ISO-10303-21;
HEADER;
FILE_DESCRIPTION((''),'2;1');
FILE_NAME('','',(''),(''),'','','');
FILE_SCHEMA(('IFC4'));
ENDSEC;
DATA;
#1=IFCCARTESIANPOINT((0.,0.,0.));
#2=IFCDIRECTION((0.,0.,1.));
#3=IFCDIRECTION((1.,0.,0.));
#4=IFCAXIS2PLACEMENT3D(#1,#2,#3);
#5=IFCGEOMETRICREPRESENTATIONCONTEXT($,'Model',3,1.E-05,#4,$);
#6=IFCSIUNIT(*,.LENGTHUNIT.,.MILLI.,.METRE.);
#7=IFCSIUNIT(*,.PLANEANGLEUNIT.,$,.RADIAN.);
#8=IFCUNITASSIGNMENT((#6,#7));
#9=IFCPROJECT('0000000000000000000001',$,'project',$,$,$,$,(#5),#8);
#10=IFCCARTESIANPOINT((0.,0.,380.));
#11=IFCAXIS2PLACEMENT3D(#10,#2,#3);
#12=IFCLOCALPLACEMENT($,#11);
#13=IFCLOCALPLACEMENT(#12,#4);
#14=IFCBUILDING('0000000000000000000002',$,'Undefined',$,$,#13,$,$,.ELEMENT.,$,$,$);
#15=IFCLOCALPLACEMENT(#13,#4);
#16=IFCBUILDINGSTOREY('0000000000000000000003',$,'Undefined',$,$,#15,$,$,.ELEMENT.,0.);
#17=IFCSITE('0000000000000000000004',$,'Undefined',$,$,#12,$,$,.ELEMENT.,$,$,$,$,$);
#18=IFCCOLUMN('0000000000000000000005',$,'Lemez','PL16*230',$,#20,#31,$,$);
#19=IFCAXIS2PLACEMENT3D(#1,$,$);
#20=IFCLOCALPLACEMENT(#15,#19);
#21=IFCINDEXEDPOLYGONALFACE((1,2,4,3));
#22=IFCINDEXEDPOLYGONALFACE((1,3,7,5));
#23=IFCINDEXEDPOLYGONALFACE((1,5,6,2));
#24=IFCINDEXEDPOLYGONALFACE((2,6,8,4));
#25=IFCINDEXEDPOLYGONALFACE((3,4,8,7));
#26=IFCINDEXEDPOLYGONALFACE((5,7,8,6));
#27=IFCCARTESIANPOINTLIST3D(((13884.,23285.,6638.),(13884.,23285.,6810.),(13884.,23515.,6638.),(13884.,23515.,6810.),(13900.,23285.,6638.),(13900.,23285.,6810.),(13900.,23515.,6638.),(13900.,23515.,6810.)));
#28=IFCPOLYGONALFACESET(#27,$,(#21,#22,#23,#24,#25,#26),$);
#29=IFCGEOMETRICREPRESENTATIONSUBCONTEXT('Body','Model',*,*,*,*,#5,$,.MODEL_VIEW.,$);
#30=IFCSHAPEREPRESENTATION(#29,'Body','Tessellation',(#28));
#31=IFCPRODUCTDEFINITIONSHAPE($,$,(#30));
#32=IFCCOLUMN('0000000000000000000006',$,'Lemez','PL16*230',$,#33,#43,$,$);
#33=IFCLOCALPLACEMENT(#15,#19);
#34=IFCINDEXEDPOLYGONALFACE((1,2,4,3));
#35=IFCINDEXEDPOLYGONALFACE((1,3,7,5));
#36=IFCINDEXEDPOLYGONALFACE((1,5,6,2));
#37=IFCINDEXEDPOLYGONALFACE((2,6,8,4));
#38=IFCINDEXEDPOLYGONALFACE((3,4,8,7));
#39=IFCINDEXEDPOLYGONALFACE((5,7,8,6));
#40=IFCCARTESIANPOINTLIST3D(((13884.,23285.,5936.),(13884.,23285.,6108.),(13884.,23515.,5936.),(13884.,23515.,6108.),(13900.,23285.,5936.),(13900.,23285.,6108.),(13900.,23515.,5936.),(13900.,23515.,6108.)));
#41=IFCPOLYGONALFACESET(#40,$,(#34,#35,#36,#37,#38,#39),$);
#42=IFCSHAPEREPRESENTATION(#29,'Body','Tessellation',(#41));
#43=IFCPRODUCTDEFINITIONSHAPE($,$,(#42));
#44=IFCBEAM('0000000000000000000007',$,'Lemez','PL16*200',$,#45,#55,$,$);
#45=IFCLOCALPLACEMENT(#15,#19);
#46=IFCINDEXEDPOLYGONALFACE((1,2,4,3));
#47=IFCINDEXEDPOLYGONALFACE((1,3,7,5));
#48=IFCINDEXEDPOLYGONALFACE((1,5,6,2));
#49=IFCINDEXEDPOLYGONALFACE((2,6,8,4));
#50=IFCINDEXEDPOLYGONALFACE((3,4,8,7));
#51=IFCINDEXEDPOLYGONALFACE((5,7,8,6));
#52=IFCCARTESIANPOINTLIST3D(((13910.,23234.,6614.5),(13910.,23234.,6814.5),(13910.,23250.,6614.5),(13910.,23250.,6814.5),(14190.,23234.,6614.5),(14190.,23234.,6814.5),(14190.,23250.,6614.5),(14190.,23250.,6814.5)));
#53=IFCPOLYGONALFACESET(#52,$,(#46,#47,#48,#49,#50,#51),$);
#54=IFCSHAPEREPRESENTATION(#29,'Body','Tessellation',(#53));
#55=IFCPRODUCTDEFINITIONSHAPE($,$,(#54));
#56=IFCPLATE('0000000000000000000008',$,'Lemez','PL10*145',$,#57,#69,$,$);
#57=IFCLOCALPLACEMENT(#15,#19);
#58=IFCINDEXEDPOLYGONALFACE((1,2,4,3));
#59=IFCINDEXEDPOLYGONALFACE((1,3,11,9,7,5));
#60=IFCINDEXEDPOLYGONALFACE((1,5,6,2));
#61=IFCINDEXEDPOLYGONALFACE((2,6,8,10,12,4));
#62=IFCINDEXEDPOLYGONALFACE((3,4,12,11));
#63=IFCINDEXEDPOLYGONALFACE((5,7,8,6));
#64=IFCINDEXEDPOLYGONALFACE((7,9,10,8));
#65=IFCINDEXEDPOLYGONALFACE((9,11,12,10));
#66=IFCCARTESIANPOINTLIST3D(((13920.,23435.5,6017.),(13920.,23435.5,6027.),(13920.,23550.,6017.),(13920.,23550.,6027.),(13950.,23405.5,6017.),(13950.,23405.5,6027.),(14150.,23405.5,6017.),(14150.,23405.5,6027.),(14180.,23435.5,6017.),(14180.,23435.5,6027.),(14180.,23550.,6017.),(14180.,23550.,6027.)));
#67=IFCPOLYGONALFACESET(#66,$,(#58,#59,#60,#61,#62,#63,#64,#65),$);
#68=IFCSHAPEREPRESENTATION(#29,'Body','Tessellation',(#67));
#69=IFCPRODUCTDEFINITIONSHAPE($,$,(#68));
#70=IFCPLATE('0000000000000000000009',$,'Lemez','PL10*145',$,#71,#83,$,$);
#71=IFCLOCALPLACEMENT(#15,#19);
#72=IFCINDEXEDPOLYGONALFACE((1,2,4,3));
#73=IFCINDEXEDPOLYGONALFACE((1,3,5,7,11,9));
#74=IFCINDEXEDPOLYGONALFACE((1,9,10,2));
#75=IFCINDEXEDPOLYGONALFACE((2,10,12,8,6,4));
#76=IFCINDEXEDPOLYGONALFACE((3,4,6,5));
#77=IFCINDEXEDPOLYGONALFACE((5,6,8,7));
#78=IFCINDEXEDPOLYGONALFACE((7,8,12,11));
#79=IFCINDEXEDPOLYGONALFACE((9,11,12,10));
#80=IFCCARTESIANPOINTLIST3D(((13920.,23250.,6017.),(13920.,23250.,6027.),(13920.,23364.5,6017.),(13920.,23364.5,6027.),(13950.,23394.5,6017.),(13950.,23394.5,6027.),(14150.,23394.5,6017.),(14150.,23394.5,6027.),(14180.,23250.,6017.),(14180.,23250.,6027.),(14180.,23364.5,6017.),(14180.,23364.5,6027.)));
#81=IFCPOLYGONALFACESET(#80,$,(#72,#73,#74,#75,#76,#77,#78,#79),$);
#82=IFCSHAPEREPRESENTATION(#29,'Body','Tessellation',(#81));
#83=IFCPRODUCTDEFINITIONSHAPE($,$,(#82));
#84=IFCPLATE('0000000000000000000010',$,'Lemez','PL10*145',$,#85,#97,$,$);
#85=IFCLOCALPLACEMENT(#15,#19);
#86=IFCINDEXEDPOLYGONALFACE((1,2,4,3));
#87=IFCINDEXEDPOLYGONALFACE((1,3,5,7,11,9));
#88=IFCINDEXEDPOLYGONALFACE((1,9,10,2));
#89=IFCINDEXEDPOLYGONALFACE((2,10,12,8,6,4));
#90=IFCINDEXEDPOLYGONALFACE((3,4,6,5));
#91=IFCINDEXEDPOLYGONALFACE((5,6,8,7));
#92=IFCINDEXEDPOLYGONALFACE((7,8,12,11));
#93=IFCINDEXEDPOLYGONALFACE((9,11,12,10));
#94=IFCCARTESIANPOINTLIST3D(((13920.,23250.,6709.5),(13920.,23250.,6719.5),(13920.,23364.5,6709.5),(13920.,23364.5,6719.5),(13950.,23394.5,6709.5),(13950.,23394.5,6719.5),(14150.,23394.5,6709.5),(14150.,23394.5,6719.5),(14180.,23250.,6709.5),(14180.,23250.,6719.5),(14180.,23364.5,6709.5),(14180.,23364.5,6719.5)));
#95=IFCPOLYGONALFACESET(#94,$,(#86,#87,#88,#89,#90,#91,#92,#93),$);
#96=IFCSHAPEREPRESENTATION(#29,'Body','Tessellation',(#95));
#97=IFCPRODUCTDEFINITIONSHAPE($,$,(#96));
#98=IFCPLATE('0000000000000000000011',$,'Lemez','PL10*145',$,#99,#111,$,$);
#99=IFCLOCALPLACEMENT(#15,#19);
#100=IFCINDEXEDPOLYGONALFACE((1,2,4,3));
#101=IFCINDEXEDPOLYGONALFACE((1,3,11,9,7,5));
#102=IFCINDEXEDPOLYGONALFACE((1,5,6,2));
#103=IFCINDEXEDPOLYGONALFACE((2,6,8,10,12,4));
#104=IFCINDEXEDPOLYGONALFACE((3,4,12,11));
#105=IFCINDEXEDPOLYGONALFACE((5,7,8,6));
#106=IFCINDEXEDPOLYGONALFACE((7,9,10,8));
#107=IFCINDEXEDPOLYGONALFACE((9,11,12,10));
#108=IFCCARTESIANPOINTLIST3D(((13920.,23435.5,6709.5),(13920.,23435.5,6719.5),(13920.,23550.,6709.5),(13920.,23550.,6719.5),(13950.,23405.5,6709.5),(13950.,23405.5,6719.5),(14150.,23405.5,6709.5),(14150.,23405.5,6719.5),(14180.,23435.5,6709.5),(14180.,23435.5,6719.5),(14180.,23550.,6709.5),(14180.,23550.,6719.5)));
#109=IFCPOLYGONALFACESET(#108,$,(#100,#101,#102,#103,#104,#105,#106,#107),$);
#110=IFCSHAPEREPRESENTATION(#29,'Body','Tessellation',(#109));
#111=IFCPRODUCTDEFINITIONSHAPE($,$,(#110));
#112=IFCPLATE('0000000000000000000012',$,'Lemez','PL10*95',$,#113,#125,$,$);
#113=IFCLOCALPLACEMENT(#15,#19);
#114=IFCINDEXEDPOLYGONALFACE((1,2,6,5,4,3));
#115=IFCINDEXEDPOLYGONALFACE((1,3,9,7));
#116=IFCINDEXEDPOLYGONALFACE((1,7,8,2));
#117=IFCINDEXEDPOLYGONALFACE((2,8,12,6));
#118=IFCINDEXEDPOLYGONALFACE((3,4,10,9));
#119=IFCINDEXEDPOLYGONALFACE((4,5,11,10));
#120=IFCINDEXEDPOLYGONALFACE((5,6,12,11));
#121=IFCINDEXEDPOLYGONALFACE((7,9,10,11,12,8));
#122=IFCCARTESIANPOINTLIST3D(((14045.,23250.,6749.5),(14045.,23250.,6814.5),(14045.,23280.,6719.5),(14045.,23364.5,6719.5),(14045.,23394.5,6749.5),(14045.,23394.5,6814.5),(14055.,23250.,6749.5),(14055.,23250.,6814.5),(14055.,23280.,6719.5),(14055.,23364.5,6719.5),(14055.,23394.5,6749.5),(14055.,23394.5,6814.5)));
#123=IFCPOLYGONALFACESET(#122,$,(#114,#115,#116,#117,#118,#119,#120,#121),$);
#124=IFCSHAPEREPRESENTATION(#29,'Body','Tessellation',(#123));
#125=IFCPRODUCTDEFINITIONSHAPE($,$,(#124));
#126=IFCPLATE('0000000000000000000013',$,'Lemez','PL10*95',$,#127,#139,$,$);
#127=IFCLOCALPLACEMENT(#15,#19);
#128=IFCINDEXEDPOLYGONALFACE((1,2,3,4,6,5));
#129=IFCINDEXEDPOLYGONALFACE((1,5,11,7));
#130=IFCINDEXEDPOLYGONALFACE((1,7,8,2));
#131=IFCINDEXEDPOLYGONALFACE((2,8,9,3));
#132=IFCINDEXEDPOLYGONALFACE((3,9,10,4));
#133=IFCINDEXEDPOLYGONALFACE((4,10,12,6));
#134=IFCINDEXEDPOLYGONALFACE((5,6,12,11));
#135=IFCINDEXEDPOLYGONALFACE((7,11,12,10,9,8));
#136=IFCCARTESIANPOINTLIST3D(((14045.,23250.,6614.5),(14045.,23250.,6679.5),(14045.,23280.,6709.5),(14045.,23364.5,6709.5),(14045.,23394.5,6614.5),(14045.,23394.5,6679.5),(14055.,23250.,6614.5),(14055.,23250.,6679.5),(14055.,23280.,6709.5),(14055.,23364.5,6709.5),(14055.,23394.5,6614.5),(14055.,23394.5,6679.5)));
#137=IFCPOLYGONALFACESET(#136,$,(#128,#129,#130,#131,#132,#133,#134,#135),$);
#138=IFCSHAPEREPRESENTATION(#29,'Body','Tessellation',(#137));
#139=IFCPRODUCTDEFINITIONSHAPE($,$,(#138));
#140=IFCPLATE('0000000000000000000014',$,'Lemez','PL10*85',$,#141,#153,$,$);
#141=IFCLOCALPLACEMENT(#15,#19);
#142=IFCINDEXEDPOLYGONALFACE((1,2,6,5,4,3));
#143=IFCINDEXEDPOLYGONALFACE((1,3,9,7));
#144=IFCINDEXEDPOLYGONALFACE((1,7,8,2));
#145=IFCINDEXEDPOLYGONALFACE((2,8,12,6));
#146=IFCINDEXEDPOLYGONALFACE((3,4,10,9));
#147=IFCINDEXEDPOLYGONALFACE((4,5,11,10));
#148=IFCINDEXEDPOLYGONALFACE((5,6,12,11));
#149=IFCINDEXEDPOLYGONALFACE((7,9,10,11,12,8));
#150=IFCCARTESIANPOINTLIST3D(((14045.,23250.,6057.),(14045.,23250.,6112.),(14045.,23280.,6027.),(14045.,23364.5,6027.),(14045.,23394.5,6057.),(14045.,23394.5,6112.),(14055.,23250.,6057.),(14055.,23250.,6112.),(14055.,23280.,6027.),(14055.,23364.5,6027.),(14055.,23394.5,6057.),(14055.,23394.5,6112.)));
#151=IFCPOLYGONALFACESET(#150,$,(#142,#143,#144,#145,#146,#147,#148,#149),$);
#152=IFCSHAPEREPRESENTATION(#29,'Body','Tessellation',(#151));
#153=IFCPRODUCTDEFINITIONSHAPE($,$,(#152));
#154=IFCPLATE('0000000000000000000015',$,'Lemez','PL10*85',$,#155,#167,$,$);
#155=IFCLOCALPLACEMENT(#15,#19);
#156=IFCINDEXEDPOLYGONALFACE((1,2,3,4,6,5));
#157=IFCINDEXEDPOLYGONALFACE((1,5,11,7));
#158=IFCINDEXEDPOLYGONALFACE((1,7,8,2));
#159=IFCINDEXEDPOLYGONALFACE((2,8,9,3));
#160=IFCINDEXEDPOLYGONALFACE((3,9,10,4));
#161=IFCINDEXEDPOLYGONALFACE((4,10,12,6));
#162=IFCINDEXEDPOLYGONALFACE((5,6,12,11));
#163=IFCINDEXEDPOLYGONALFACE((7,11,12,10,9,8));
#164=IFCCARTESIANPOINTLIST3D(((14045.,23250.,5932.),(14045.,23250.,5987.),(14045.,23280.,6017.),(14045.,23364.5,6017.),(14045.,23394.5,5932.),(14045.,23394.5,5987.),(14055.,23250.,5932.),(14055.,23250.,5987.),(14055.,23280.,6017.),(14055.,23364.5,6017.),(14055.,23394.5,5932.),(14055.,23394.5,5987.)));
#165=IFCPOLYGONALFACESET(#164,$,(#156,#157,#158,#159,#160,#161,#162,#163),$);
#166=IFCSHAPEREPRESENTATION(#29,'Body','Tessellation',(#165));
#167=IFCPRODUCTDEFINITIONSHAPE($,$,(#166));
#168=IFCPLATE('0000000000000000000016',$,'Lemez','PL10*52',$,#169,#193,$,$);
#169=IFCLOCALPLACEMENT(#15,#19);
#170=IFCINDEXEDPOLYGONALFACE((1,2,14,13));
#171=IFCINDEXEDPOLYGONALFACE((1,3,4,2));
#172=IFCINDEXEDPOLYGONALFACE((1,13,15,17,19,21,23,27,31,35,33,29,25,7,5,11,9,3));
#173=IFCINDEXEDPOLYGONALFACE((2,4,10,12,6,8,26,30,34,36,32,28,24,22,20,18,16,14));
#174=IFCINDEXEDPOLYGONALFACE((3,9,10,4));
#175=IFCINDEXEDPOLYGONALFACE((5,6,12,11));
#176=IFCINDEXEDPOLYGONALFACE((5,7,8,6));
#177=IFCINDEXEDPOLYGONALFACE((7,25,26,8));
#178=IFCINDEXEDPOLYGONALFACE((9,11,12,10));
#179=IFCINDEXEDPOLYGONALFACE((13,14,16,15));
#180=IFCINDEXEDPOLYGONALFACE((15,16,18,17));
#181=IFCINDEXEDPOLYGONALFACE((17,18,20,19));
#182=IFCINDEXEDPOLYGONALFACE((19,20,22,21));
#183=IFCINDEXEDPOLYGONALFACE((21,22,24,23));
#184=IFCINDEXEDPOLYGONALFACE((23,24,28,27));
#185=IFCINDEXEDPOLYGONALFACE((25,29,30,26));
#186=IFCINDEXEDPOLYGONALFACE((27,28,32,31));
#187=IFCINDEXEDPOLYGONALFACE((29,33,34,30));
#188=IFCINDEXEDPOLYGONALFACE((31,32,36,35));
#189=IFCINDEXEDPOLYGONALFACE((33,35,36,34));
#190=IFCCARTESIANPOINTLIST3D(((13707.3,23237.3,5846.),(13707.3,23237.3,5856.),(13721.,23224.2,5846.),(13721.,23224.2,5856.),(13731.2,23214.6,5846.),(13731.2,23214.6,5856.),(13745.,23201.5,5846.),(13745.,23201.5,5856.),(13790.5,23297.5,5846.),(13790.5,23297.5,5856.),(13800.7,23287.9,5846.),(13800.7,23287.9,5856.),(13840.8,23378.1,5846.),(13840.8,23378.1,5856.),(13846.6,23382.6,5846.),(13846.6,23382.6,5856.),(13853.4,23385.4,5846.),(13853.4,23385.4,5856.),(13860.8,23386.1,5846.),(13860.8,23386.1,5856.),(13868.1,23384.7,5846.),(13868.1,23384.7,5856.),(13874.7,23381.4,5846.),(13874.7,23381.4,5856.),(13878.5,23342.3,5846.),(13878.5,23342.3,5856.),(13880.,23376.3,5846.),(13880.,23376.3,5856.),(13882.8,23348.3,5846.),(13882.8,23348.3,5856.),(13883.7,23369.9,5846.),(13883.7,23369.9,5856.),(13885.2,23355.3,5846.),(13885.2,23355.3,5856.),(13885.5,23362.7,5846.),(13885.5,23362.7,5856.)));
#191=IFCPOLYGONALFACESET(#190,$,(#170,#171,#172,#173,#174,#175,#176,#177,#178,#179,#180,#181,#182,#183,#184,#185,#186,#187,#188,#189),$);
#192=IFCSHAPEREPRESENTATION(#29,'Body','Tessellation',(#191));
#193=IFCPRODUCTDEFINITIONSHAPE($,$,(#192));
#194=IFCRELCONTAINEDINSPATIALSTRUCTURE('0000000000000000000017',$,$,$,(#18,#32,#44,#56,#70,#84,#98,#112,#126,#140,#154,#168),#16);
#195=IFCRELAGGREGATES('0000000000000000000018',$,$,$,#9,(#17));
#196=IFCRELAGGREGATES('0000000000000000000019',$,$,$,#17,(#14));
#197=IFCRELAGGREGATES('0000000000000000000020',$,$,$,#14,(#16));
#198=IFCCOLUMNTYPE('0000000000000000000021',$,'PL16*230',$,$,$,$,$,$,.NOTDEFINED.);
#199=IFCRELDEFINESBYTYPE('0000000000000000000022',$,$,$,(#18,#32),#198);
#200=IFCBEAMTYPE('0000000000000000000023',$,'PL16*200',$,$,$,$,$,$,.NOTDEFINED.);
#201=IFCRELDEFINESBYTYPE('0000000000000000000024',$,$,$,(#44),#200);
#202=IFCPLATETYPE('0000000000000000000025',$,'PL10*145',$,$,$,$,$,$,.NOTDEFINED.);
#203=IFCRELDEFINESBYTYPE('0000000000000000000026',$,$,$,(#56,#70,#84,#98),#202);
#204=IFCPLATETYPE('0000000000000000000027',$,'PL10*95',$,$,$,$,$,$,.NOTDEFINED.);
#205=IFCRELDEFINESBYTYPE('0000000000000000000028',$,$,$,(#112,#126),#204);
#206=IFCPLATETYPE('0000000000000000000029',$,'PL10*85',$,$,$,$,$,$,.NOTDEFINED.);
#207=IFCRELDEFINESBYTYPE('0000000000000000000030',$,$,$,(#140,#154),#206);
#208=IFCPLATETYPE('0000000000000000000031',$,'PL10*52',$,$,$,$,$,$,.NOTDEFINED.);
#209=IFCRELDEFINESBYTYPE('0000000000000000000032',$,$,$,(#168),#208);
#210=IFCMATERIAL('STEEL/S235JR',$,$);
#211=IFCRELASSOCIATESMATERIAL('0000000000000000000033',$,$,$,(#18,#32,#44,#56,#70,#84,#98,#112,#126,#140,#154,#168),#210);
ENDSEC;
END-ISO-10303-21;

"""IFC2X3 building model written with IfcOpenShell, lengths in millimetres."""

from ifc_helpers import new_model, si_unit, frame, frame_2d, origin_with_axes, origin_2d_with_axis, place, context, subcontext, project, spatial, polyline, circle_curve, parameter, trimmed, segment, composite_curve, rectangle, outline, extrude, boolean, material, type_object, element, save


model = new_model("IFC2X3")

# Units and contexts
model_context = context("Model", 3, precision=1e-05, world=origin_with_axes())
body_context = subcontext(model_context, "Body", "Model", "MODEL_VIEW")
ifc_project = project(units=[si_unit("LENGTHUNIT", "METRE", prefix="MILLI"), si_unit("PLANEANGLEUNIT", "RADIAN")], contexts=[model_context])

# Site, building, storey
site_placement = place(None, frame((0.0, 0.0, 380.0), z_axis=(0.0, 0.0, 1.0), x_axis=(1.0, 0.0, 0.0)))
site = spatial("IfcSite", under=ifc_project, at=site_placement, Name="Undefined", CompositionType="ELEMENT")
building_placement = place(site_placement, origin_with_axes())
building = spatial("IfcBuilding", under=site, at=building_placement, Name="Undefined", CompositionType="ELEMENT")
storey_placement = place(building_placement, origin_with_axes())
storey = spatial("IfcBuildingStorey", under=building, at=storey_placement, Name="Undefined", CompositionType="ELEMENT", Elevation=0.0)

# Columns
ifc_material_1 = material(Name="STEEL/S235JR")
column_type = type_object("IfcColumnType", Name="PL16*230", PredefinedType="NOTDEFINED")
for number, where, z_axis, x_axis, name in (
    (1, (13892.0, 23400.0, 6638.0), (0.0, 0.0, 1.0), (0.0, 1.0, 0.0), "Lemez"),
    (2, (13892.0, 23400.0, 5936.0), (0.0, 0.0, 1.0), (0.0, 1.0, 0.0), "Lemez"),
):
    element("IfcColumn", number, at=place(storey_placement, frame(where, z_axis=z_axis, x_axis=x_axis)), inside=storey, type_object=column_type, material=ifc_material_1, Name=name, Description="PL16*230", context=body_context, shape_type="SweptSolid", body=[
        extrude(rectangle(XDim=16.0, YDim=230.0, at=origin_2d_with_axis()), frame((0.0, 0.0, 172.0), z_axis=(0.0, 0.0, -1.0), x_axis=(0.0, 1.0, 0.0)), (0.0, 0.0, 1.0), 172.0),
    ])

# Beam
beam_type_1 = type_object("IfcBeamType", Name="PL16*200", PredefinedType="NOTDEFINED")
beam_1_placement = place(storey_placement, frame((14190.0, 23242.0, 6714.5), z_axis=(0.0, 0.0, -1.0), x_axis=(-1.0, 0.0, 0.0)))
element("IfcBeam", 3, at=beam_1_placement, inside=storey, type_object=beam_type_1, material=ifc_material_1, Name="Lemez", Description="PL16*200", context=body_context, shape_type="SweptSolid", body=[
    extrude(rectangle(XDim=16.0, YDim=200.0, at=origin_2d_with_axis()), frame((280.0, 0.0, 0.0), z_axis=(-1.0, 0.0, 0.0), x_axis=(0.0, -1.0, 0.0)), (0.0, 0.0, 1.0), 280.0),
])

# Plates
plate_type_1 = type_object("IfcPlateType", Name="PL10*145", PredefinedType="NOTDEFINED")
for number, where, z_axis, x_axis, name in (
    (4, (14180.0, 23405.5, 6022.0), (0.0, 0.0, 1.0), (0.0, 1.0, 0.0), "Lemez"),
    (5, (14180.0, 23394.5, 6022.0), (0.0, 0.0, -1.0), (0.0, -1.0, 0.0), "Lemez"),
    (6, (14180.0, 23394.5, 6714.5), (0.0, 0.0, -1.0), (0.0, -1.0, 0.0), "Lemez"),
    (7, (14180.0, 23405.5, 6714.5), (0.0, 0.0, 1.0), (0.0, 1.0, 0.0), "Lemez"),
):
    element("IfcPlate", number, at=place(storey_placement, frame(where, z_axis=z_axis, x_axis=x_axis)), inside=storey, type_object=plate_type_1, material=ifc_material_1, Name=name, Description="PL10*145", context=body_context, shape_type="SweptSolid", body=[
        extrude(outline(polyline([(0.0, 30.0), (30.0, 0.0), (144.5, 0.0), (144.5, 260.0), (30.0, 260.0), (0.0, 230.0), (0.0, 30.0)])), frame((0.0, 0.0, -5.0), z_axis=(0.0, 0.0, 1.0), x_axis=(1.0, 0.0, 0.0)), (0.0, 0.0, 1.0), 10.0),
    ])
plate_type_2 = type_object("IfcPlateType", Name="PL10*95", PredefinedType="NOTDEFINED")
plate_1_placement = place(storey_placement, frame((14050.0, 23250.0, 6814.5), z_axis=(-1.0, 0.0, 0.0), x_axis=(0.0, 1.0, 0.0)))
element("IfcPlate", 8, at=plate_1_placement, inside=storey, type_object=plate_type_2, material=ifc_material_1, Name="Lemez", Description="PL10*95", context=body_context, shape_type="SweptSolid", body=[
    extrude(outline(polyline([(0.0, 0.0), (144.5, 0.0), (144.5, 65.0), (114.5, 95.0), (30.0, 95.0), (0.0, 65.0), (0.0, 0.0)])), frame((0.0, 0.0, -5.0), z_axis=(0.0, 0.0, 1.0), x_axis=(1.0, 0.0, 0.0)), (0.0, 0.0, 1.0), 10.0),
])
plate_2_placement = place(storey_placement, frame((14050.0, 23250.0, 6709.5), z_axis=(-1.0, 0.0, 0.0), x_axis=(0.0, 1.0, 0.0)))
element("IfcPlate", 9, at=plate_2_placement, inside=storey, type_object=plate_type_2, material=ifc_material_1, Name="Lemez", Description="PL10*95", context=body_context, shape_type="SweptSolid", body=[
    extrude(outline(polyline([(0.0, 30.0), (30.0, 0.0), (114.5, 0.0), (144.5, 30.0), (144.5, 95.0), (0.0, 95.0), (0.0, 30.0)])), frame((0.0, 0.0, -5.0), z_axis=(0.0, 0.0, 1.0), x_axis=(1.0, 0.0, 0.0)), (0.0, 0.0, 1.0), 10.0),
])
plate_type_3 = type_object("IfcPlateType", Name="PL10*85", PredefinedType="NOTDEFINED")
plate_3_placement = place(storey_placement, frame((14050.0, 23250.0, 6112.0), z_axis=(-1.0, 0.0, 0.0), x_axis=(0.0, 1.0, 0.0)))
element("IfcPlate", 10, at=plate_3_placement, inside=storey, type_object=plate_type_3, material=ifc_material_1, Name="Lemez", Description="PL10*85", context=body_context, shape_type="SweptSolid", body=[
    extrude(outline(polyline([(0.0, 0.0), (144.5, 0.0), (144.5, 55.0), (114.5, 85.0), (30.0, 85.0), (0.0, 55.0), (0.0, 0.0)])), frame((0.0, 0.0, -5.0), z_axis=(0.0, 0.0, 1.0), x_axis=(1.0, 0.0, 0.0)), (0.0, 0.0, 1.0), 10.0),
])
plate_4_placement = place(storey_placement, frame((14050.0, 23250.0, 6017.0), z_axis=(-1.0, 0.0, 0.0), x_axis=(0.0, 1.0, 0.0)))
element("IfcPlate", 11, at=plate_4_placement, inside=storey, type_object=plate_type_3, material=ifc_material_1, Name="Lemez", Description="PL10*85", context=body_context, shape_type="SweptSolid", body=[
    extrude(outline(polyline([(0.0, 30.0), (30.0, 0.0), (114.5, 0.0), (144.5, 30.0), (144.5, 85.0), (0.0, 85.0), (0.0, 30.0)])), frame((0.0, 0.0, -5.0), z_axis=(0.0, 0.0, 1.0), x_axis=(1.0, 0.0, 0.0)), (0.0, 0.0, 1.0), 10.0),
])
plate_type_4 = type_object("IfcPlateType", Name="PL10*52", PredefinedType="NOTDEFINED")
for number, where, z_axis, x_axis, name in (
    (12, (13896.4, 23361.1, 5851.0), (0.0, 0.0, 1.0), (-0.725464, 0.68826, 0.0), "Lemez"),
):
    element("IfcPlate", number, at=place(storey_placement, frame(where, z_axis=z_axis, x_axis=x_axis)), inside=storey, type_object=plate_type_4, material=ifc_material_1, Name=name, Description="PL10*52", context=body_context, shape_type="CSG", body=[
        boolean("DIFFERENCE", extrude(outline(composite_curve([segment(trimmed(circle_curve(frame_2d((26.0, 26.0), x_axis=(-1.0, 0.0)), 26.0), [parameter(0.0)], [parameter(1.570796)], True, "PARAMETER"), True, "CONTINUOUS"), segment(trimmed(circle_curve(frame_2d((26.0, 26.0), x_axis=(0.0, -1.0)), 26.0), [parameter(0.0)], [parameter(1.570796)], True, "PARAMETER"), True, "CONTINUOUS"), segment(polyline([(52.0, 26.0), (52.0, 220.0), (0.0, 220.0), (0.0, 26.0)]), True, "CONTINUOUS")], self_intersect=True)), frame((0.0, 0.0, -5.0), z_axis=(0.0, 0.0, 1.0), x_axis=(1.0, 0.0, 0.0)), (0.0, 0.0, 1.0), 10.0), extrude(rectangle(XDim=14.0, YDim=14.0, at=origin_2d_with_axis()), frame((26.0, 320.0, 0.0), z_axis=(0.0, -1.0, 0.0), x_axis=(1.0, 0.0, 0.0)), (0.0, 0.0, 1.0), 201.0)),
    ])

save(model, "model.ifc")
